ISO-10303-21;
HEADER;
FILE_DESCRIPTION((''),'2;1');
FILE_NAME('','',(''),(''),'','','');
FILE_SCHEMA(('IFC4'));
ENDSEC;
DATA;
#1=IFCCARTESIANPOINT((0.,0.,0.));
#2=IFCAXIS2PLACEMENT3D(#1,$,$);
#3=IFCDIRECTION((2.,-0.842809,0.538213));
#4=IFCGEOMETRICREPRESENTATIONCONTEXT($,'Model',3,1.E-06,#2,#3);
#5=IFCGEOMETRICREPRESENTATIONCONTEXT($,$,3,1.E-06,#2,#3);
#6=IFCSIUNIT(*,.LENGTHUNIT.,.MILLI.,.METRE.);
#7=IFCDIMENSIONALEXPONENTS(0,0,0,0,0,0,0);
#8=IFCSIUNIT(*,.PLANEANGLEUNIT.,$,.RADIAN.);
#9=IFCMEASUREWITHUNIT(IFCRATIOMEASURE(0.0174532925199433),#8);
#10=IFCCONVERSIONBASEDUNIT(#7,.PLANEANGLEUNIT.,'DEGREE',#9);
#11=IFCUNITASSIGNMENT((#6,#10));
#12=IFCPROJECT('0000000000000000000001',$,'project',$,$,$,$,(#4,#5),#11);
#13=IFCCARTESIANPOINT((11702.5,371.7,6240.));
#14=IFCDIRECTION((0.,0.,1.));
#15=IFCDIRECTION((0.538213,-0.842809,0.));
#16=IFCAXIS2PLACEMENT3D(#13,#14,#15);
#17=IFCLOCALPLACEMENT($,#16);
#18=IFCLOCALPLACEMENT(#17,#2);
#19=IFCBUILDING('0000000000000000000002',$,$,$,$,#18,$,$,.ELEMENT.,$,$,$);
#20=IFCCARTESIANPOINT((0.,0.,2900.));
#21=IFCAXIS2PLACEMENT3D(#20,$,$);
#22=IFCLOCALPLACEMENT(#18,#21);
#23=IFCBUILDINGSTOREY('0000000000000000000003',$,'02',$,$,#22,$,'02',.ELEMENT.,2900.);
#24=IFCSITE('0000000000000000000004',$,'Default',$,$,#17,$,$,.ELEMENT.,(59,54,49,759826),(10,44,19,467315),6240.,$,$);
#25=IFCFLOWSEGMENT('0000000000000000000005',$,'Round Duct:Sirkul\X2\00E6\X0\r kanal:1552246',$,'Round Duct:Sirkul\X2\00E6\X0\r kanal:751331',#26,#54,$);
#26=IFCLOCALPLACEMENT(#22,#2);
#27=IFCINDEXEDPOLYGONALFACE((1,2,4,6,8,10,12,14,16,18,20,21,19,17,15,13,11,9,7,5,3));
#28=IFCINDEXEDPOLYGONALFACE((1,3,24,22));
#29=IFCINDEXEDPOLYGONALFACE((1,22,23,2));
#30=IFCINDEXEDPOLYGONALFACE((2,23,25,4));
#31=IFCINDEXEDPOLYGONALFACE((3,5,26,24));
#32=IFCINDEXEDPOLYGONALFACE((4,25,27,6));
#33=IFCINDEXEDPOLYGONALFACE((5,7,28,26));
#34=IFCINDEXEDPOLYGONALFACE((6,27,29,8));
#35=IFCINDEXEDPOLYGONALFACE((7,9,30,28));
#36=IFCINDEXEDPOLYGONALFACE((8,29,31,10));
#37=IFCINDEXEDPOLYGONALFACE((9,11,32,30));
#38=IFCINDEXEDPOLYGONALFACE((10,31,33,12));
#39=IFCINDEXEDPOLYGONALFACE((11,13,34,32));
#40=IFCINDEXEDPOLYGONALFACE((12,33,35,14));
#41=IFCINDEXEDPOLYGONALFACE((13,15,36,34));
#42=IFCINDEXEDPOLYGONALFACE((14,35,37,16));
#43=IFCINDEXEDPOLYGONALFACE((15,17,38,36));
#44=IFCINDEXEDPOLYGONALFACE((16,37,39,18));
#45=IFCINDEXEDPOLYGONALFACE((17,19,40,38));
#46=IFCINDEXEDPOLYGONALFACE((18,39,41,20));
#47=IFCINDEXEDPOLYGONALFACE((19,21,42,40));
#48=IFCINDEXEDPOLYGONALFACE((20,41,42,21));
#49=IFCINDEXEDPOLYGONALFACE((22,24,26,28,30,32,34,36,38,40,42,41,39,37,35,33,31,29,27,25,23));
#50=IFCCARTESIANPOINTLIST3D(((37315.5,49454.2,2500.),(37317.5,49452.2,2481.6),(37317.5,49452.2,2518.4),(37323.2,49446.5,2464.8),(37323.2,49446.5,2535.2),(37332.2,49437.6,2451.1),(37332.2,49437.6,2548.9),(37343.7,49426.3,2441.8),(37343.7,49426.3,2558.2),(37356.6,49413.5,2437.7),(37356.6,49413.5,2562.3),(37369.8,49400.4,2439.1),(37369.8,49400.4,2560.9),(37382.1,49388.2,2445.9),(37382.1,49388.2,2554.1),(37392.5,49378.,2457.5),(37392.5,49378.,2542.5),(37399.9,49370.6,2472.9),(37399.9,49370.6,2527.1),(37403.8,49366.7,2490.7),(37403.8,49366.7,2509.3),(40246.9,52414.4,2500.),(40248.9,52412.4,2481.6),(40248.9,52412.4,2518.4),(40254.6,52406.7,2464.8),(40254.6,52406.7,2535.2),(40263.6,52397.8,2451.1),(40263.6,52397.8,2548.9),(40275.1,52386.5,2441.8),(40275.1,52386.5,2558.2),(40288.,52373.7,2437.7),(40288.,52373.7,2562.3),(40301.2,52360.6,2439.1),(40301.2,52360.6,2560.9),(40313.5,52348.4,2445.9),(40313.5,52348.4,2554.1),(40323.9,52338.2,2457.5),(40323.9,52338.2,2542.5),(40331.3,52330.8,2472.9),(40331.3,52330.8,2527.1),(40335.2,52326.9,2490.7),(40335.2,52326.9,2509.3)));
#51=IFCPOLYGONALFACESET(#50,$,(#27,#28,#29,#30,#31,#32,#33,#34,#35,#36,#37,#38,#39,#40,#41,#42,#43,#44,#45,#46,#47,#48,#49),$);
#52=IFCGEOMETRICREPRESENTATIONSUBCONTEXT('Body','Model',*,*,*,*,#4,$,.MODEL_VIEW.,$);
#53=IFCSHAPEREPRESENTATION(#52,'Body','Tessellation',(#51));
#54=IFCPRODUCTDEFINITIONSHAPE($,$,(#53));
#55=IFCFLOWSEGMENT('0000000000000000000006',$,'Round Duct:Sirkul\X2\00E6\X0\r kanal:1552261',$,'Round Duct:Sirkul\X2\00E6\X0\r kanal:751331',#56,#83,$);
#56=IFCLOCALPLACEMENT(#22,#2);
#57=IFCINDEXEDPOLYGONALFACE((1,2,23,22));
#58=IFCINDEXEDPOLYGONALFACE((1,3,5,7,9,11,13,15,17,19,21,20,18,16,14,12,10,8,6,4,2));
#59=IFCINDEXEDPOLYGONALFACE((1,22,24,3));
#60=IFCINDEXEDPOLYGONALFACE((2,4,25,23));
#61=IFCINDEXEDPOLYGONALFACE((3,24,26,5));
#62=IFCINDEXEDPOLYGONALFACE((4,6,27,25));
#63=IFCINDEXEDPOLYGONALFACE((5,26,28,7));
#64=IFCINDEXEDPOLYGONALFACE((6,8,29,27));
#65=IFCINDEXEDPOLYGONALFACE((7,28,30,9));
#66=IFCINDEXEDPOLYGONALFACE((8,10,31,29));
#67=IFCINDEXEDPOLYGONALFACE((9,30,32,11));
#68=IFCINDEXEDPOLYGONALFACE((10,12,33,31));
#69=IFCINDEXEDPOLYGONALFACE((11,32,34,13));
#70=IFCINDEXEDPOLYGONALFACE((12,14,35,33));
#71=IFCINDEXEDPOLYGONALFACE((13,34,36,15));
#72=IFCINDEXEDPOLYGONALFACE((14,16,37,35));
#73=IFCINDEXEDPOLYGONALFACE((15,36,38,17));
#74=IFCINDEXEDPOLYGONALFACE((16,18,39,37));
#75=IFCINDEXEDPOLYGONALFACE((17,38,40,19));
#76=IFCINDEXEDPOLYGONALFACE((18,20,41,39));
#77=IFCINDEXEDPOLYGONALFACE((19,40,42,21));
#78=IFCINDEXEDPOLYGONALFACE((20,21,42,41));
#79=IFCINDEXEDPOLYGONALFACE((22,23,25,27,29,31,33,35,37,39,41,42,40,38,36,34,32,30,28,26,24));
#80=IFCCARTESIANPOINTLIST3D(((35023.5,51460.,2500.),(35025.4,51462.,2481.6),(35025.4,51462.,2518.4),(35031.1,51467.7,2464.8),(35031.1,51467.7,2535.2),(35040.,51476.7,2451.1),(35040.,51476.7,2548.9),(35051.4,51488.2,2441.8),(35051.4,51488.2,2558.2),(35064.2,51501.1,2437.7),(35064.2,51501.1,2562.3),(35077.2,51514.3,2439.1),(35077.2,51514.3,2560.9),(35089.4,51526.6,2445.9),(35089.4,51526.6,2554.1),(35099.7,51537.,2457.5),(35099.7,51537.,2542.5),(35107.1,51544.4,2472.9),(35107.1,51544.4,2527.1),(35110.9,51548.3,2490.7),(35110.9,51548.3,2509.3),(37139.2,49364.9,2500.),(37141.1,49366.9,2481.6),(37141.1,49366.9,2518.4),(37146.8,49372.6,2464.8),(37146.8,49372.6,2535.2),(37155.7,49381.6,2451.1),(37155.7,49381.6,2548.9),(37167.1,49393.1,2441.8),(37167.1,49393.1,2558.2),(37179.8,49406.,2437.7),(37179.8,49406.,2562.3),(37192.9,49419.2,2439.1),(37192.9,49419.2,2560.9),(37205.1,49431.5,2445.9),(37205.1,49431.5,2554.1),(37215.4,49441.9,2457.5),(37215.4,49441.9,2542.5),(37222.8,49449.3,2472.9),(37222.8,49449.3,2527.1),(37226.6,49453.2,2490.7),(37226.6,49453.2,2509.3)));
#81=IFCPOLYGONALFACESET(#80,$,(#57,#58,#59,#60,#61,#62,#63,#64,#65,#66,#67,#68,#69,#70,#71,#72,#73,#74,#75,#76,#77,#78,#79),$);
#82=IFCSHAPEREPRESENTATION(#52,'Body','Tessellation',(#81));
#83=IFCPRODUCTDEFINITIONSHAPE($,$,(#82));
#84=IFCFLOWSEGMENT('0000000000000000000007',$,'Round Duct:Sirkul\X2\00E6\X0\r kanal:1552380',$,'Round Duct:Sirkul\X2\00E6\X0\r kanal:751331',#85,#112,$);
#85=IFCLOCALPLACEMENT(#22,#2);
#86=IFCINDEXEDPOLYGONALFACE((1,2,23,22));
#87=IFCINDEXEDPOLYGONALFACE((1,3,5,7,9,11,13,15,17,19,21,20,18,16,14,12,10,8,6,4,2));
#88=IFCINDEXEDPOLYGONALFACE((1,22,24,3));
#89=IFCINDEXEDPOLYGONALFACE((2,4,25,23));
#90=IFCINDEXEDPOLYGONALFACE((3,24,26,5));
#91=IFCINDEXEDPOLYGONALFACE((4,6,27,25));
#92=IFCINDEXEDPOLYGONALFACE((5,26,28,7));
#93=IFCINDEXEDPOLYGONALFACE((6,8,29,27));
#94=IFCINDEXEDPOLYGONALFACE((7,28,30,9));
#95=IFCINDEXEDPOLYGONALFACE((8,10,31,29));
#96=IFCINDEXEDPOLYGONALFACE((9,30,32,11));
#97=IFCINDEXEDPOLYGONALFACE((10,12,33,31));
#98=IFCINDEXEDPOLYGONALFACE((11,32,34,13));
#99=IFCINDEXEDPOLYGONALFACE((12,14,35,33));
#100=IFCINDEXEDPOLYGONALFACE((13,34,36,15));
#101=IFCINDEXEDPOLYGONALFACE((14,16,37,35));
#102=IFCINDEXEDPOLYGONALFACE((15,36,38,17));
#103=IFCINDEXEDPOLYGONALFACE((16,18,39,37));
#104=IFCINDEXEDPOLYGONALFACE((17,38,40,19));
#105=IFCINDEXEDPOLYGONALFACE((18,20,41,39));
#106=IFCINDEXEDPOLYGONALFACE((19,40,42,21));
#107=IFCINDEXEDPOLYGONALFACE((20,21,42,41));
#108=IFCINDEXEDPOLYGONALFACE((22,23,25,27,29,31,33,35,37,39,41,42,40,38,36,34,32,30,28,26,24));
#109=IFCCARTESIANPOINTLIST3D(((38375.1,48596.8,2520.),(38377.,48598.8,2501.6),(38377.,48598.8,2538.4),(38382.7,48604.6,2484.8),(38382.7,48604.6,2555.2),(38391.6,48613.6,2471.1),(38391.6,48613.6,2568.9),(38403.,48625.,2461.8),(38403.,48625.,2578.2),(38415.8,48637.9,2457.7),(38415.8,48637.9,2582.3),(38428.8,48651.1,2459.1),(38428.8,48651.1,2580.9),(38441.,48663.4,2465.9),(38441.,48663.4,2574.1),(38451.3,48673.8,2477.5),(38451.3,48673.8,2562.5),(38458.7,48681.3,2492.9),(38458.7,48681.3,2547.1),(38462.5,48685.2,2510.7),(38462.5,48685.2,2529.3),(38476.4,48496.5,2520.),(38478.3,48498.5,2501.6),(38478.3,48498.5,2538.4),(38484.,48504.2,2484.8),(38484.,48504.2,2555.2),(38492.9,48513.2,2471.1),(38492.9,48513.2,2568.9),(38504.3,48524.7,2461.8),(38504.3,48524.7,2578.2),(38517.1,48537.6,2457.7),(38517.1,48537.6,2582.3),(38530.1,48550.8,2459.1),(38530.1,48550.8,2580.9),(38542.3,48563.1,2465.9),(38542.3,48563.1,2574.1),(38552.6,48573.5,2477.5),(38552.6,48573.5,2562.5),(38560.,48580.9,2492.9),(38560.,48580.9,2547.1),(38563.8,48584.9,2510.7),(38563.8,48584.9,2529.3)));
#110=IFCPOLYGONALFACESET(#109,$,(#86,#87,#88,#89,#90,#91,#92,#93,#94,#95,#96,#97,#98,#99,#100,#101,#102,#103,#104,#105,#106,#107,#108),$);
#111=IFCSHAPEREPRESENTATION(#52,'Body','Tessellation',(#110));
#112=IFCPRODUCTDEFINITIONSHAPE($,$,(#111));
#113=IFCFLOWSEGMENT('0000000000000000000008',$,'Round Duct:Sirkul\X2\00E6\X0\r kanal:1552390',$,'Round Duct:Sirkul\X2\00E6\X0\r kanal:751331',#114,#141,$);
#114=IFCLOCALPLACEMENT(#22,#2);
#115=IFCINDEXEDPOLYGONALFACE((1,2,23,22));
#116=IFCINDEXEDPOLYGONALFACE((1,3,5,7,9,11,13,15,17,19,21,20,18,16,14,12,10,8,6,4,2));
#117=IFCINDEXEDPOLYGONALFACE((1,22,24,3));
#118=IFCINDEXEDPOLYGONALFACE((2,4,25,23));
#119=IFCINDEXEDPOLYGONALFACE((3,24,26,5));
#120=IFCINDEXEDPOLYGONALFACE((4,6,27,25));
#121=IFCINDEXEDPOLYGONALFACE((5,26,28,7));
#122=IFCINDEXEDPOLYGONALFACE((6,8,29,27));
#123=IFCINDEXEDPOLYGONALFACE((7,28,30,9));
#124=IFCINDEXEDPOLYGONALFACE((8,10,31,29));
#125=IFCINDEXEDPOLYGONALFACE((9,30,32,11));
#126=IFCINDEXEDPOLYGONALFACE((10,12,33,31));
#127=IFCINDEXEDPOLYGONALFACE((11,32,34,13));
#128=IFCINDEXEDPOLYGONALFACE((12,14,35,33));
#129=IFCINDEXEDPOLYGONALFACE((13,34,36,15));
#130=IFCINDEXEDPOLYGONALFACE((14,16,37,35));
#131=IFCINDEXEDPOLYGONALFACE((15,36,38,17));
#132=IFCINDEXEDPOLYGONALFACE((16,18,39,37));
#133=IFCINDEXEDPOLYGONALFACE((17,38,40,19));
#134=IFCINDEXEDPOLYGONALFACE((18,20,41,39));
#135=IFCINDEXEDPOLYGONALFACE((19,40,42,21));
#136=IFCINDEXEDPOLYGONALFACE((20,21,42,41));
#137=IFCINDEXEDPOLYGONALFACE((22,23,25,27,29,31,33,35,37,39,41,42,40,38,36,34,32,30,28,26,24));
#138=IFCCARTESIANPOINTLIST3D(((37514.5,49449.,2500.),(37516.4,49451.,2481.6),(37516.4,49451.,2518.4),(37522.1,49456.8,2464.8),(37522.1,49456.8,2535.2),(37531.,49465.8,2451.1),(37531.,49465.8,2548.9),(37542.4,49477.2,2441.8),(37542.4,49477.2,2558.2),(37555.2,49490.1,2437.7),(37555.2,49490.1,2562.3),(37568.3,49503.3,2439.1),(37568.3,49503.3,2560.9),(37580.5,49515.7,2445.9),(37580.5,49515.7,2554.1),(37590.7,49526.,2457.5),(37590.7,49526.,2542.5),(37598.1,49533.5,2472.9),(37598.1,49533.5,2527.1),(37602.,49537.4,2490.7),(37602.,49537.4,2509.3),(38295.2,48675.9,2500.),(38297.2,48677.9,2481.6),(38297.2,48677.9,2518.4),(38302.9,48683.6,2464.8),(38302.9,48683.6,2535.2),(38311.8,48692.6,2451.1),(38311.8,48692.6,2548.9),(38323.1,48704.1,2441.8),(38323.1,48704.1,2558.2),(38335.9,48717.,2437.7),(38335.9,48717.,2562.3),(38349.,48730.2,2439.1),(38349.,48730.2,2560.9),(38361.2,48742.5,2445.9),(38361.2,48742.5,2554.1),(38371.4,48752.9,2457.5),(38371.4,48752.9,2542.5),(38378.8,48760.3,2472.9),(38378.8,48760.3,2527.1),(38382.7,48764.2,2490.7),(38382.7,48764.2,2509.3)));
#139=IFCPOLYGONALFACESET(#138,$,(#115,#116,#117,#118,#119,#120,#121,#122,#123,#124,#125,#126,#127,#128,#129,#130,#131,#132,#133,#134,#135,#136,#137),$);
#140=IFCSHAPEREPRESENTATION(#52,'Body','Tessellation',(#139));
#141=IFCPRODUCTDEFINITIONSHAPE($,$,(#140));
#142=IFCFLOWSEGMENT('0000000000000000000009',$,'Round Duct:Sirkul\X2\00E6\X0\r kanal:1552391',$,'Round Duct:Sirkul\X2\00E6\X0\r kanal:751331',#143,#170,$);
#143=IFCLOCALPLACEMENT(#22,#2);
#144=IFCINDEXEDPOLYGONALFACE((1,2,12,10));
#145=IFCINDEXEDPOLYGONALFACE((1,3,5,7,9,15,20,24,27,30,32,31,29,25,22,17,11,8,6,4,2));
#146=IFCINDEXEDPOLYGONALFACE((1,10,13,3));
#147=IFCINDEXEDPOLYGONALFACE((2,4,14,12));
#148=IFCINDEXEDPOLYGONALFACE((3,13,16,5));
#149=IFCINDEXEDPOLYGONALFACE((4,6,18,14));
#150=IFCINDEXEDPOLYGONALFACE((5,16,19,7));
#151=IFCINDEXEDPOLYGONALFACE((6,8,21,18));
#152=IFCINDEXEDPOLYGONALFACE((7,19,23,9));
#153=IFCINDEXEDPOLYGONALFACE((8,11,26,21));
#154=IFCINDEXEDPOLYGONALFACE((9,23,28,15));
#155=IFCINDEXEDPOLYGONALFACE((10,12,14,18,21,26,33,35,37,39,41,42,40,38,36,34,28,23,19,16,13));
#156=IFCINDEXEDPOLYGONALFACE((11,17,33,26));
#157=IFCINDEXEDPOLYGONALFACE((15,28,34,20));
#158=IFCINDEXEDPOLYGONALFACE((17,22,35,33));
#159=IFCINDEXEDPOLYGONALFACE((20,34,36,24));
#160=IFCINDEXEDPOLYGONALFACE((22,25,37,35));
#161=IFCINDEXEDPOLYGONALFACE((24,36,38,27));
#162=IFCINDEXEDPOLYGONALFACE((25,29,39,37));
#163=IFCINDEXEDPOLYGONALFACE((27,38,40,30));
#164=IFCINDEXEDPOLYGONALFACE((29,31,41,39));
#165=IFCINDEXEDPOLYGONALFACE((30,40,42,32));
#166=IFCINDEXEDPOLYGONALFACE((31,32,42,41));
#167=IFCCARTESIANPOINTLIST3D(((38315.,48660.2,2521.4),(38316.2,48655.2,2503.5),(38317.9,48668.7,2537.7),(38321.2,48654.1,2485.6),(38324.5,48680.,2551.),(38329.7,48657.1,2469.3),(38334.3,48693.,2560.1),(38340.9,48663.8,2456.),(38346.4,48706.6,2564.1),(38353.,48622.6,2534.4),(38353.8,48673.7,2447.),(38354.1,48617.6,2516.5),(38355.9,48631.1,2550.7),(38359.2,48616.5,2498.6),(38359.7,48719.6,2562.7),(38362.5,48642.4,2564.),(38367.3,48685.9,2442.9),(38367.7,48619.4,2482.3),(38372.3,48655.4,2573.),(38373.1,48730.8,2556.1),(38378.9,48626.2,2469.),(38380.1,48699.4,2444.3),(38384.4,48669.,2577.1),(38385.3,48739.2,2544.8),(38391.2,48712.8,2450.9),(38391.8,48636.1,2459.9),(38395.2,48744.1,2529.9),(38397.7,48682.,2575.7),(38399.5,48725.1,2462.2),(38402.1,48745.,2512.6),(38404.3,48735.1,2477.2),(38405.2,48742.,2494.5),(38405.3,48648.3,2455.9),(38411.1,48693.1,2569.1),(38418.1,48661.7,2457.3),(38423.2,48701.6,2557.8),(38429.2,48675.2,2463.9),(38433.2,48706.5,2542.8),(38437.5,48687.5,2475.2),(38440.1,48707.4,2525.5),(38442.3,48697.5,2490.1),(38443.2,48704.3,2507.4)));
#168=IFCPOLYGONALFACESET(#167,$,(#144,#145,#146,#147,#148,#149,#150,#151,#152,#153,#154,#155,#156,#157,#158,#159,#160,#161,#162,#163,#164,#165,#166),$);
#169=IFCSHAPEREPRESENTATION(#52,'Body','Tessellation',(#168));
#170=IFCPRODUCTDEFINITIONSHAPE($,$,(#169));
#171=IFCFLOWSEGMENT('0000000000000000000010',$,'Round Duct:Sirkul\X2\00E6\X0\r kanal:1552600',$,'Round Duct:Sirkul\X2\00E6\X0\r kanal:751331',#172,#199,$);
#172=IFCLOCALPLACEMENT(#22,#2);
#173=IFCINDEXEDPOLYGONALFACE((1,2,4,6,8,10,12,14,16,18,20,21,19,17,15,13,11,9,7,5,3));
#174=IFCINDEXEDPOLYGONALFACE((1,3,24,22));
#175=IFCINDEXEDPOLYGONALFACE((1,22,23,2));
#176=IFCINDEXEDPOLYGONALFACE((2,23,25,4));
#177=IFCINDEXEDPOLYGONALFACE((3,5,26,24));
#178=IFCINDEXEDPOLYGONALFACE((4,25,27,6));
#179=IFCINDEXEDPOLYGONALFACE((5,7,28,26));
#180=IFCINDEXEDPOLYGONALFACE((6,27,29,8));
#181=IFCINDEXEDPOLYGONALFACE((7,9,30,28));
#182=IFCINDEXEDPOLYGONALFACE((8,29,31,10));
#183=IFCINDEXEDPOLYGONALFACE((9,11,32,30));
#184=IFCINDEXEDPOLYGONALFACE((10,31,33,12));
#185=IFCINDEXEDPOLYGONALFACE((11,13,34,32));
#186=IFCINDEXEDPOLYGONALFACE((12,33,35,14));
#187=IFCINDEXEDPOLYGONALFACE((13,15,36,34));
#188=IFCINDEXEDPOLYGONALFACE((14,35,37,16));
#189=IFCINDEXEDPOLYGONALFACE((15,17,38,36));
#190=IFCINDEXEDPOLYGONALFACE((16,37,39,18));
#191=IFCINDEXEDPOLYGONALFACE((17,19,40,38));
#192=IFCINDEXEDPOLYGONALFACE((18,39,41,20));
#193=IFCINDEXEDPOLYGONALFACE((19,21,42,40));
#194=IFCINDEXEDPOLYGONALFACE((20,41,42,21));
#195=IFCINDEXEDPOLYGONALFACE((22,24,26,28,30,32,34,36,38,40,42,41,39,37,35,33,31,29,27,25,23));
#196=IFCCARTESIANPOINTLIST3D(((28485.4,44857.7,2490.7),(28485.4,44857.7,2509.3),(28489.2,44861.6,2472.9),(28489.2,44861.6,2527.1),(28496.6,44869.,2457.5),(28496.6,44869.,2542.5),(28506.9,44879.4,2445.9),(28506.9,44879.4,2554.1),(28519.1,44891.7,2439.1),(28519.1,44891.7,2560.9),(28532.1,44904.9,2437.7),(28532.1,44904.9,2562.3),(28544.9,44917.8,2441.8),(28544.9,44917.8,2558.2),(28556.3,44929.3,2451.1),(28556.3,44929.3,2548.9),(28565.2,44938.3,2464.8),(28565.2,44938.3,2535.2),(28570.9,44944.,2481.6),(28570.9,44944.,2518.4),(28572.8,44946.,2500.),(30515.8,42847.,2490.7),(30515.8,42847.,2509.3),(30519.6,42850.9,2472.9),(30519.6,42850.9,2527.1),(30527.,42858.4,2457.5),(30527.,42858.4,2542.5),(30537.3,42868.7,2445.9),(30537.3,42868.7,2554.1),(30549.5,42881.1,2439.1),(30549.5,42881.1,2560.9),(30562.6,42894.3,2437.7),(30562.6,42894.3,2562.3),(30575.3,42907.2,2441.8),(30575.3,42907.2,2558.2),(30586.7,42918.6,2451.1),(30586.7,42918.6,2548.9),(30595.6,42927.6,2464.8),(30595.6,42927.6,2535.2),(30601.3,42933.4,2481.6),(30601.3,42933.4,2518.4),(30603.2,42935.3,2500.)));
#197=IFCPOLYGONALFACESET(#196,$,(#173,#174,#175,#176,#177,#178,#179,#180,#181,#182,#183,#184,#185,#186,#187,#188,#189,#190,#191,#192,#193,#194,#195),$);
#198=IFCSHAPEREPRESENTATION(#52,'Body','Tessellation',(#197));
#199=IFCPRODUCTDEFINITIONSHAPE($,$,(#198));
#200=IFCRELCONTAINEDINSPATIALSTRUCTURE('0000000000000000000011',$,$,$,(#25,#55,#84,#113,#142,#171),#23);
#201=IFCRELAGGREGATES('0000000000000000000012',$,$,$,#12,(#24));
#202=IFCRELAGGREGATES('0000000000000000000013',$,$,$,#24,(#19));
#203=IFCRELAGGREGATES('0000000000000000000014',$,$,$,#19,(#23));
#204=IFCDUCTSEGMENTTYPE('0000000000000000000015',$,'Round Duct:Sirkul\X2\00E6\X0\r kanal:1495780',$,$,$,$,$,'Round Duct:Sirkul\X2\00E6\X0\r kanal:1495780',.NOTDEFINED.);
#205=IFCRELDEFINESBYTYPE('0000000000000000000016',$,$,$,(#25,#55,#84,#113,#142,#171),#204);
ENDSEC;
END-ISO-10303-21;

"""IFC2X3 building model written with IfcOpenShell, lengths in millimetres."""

from ifc_helpers import new_model, entity, si_unit, converted_unit, direction, frame, origin, origin_2d_with_axis, place, context, subcontext, project, spatial, circle, extrude, type_object, element, save


model = new_model("IFC2X3")

# Units and contexts
model_context = context("Model", 3, precision=1e-06, world=origin(), true_north=direction((2.0, -0.842809, 0.538213)))
context_of_model = context(None, 3, precision=1e-06, world=origin(), true_north=direction((2.0, -0.842809, 0.538213)))
body_context = subcontext(model_context, "Body", "Model", "MODEL_VIEW")
ifc_project = project(units=[si_unit("LENGTHUNIT", "METRE", prefix="MILLI"), converted_unit("PLANEANGLEUNIT", "DEGREE", entity("IfcRatioMeasure", 0.0174532925199433), si_unit("PLANEANGLEUNIT", "RADIAN"), dimensions=[0, 0, 0, 0, 0, 0, 0])], contexts=[model_context, context_of_model])

# Site, building, storey
site_placement = place(None, frame((11702.5, 371.7, 6240.0), z_axis=(0.0, 0.0, 1.0), x_axis=(0.538213, -0.842809, 0.0)))
site = spatial("IfcSite", under=ifc_project, at=site_placement, Name="Default", CompositionType="ELEMENT", RefLatitude=(59, 54, 49, 759826), RefLongitude=(10, 44, 19, 467315), RefElevation=6240.0)
building_placement = place(site_placement, origin())
building = spatial("IfcBuilding", under=site, at=building_placement, CompositionType="ELEMENT")
storey_placement = place(building_placement, frame((0.0, 0.0, 2900.0)))
storey = spatial("IfcBuildingStorey", under=building, at=storey_placement, Name="02", LongName="02", CompositionType="ELEMENT", Elevation=2900.0)

# Flow segments
duct_segment_type = type_object("IfcDuctSegmentType", Name="Round Duct:Sirkulær kanal:1495780", ElementType="Round Duct:Sirkulær kanal:1495780", PredefinedType="NOTDEFINED")
flow_segment_1_placement = place(storey_placement, origin())
element("IfcFlowSegment", 1, at=flow_segment_1_placement, inside=storey, type_object=duct_segment_type, Name="Round Duct:Sirkulær kanal:1552246", ObjectType="Round Duct:Sirkulær kanal:751331", context=body_context, shape_type="SweptSolid", body=[
    extrude(circle(Radius=62.5, at=origin_2d_with_axis()), frame((37359.9, 49410.2, 2500.0), z_axis=(0.703643, 0.710553, 0.0), x_axis=(-0.710553, 0.703643, 0.0)), (0.0, 0.0, 1.0), 4166.1),
])
flow_segment_2_placement = place(storey_placement, origin())
element("IfcFlowSegment", 2, at=flow_segment_2_placement, inside=storey, type_object=duct_segment_type, Name="Round Duct:Sirkulær kanal:1552261", ObjectType="Round Duct:Sirkulær kanal:751331", context=body_context, shape_type="SweptSolid", body=[
    extrude(circle(Radius=62.5, at=origin_2d_with_axis()), frame((35067.5, 51504.4, 2500.0), z_axis=(0.710554, -0.703643, 0.0), x_axis=(-0.703643, -0.710554, 0.0)), (0.0, 0.0, 1.0), 2977.5),
])
flow_segment_3_placement = place(storey_placement, origin())
element("IfcFlowSegment", 3, at=flow_segment_3_placement, inside=storey, type_object=duct_segment_type, Name="Round Duct:Sirkulær kanal:1552380", ObjectType="Round Duct:Sirkulær kanal:751331", context=body_context, shape_type="SweptSolid", body=[
    extrude(circle(Radius=62.5, at=origin_2d_with_axis()), frame((38419.0, 48641.2, 2520.0), z_axis=(0.710554, -0.703643, 0.0), x_axis=(-0.703643, -0.710554, 0.0)), (0.0, 0.0, 1.0), 142.6),
])
flow_segment_4_placement = place(storey_placement, origin())
element("IfcFlowSegment", 4, at=flow_segment_4_placement, inside=storey, type_object=duct_segment_type, Name="Round Duct:Sirkulær kanal:1552390", ObjectType="Round Duct:Sirkulær kanal:751331", context=body_context, shape_type="SweptSolid", body=[
    extrude(circle(Radius=62.5, at=origin_2d_with_axis()), frame((38339.2, 48720.3, 2500.0), z_axis=(-0.710554, 0.703643, 0.0), x_axis=(-0.703643, -0.710554, 0.0)), (0.0, 0.0, 1.0), 1098.8),
])
flow_segment_5_placement = place(storey_placement, origin())
element("IfcFlowSegment", 5, at=flow_segment_5_placement, inside=storey, type_object=duct_segment_type, Name="Round Duct:Sirkulær kanal:1552391", ObjectType="Round Duct:Sirkulær kanal:751331", context=body_context, shape_type="SweptSolid", body=[
    extrude(circle(Radius=62.5, at=origin_2d_with_axis()), frame((38360.1, 48699.6, 2503.5), z_axis=(0.690552, -0.683835, 0.2356), x_axis=(-0.703643, -0.710554, 0.0)), (0.0, 0.0, 1.0), 55.0),
])
flow_segment_6_placement = place(storey_placement, origin())
element("IfcFlowSegment", 6, at=flow_segment_6_placement, inside=storey, type_object=duct_segment_type, Name="Round Duct:Sirkulær kanal:1552600", ObjectType="Round Duct:Sirkulær kanal:751331", context=body_context, shape_type="SweptSolid", body=[
    extrude(circle(Radius=62.5, at=origin_2d_with_axis()), frame((30559.3, 42890.9, 2500.0), z_axis=(-0.710554, 0.703643, 0.0), x_axis=(0.703643, 0.710554, 0.0)), (0.0, 0.0, 1.0), 2857.5),
])

save(model, "model.ifc")
